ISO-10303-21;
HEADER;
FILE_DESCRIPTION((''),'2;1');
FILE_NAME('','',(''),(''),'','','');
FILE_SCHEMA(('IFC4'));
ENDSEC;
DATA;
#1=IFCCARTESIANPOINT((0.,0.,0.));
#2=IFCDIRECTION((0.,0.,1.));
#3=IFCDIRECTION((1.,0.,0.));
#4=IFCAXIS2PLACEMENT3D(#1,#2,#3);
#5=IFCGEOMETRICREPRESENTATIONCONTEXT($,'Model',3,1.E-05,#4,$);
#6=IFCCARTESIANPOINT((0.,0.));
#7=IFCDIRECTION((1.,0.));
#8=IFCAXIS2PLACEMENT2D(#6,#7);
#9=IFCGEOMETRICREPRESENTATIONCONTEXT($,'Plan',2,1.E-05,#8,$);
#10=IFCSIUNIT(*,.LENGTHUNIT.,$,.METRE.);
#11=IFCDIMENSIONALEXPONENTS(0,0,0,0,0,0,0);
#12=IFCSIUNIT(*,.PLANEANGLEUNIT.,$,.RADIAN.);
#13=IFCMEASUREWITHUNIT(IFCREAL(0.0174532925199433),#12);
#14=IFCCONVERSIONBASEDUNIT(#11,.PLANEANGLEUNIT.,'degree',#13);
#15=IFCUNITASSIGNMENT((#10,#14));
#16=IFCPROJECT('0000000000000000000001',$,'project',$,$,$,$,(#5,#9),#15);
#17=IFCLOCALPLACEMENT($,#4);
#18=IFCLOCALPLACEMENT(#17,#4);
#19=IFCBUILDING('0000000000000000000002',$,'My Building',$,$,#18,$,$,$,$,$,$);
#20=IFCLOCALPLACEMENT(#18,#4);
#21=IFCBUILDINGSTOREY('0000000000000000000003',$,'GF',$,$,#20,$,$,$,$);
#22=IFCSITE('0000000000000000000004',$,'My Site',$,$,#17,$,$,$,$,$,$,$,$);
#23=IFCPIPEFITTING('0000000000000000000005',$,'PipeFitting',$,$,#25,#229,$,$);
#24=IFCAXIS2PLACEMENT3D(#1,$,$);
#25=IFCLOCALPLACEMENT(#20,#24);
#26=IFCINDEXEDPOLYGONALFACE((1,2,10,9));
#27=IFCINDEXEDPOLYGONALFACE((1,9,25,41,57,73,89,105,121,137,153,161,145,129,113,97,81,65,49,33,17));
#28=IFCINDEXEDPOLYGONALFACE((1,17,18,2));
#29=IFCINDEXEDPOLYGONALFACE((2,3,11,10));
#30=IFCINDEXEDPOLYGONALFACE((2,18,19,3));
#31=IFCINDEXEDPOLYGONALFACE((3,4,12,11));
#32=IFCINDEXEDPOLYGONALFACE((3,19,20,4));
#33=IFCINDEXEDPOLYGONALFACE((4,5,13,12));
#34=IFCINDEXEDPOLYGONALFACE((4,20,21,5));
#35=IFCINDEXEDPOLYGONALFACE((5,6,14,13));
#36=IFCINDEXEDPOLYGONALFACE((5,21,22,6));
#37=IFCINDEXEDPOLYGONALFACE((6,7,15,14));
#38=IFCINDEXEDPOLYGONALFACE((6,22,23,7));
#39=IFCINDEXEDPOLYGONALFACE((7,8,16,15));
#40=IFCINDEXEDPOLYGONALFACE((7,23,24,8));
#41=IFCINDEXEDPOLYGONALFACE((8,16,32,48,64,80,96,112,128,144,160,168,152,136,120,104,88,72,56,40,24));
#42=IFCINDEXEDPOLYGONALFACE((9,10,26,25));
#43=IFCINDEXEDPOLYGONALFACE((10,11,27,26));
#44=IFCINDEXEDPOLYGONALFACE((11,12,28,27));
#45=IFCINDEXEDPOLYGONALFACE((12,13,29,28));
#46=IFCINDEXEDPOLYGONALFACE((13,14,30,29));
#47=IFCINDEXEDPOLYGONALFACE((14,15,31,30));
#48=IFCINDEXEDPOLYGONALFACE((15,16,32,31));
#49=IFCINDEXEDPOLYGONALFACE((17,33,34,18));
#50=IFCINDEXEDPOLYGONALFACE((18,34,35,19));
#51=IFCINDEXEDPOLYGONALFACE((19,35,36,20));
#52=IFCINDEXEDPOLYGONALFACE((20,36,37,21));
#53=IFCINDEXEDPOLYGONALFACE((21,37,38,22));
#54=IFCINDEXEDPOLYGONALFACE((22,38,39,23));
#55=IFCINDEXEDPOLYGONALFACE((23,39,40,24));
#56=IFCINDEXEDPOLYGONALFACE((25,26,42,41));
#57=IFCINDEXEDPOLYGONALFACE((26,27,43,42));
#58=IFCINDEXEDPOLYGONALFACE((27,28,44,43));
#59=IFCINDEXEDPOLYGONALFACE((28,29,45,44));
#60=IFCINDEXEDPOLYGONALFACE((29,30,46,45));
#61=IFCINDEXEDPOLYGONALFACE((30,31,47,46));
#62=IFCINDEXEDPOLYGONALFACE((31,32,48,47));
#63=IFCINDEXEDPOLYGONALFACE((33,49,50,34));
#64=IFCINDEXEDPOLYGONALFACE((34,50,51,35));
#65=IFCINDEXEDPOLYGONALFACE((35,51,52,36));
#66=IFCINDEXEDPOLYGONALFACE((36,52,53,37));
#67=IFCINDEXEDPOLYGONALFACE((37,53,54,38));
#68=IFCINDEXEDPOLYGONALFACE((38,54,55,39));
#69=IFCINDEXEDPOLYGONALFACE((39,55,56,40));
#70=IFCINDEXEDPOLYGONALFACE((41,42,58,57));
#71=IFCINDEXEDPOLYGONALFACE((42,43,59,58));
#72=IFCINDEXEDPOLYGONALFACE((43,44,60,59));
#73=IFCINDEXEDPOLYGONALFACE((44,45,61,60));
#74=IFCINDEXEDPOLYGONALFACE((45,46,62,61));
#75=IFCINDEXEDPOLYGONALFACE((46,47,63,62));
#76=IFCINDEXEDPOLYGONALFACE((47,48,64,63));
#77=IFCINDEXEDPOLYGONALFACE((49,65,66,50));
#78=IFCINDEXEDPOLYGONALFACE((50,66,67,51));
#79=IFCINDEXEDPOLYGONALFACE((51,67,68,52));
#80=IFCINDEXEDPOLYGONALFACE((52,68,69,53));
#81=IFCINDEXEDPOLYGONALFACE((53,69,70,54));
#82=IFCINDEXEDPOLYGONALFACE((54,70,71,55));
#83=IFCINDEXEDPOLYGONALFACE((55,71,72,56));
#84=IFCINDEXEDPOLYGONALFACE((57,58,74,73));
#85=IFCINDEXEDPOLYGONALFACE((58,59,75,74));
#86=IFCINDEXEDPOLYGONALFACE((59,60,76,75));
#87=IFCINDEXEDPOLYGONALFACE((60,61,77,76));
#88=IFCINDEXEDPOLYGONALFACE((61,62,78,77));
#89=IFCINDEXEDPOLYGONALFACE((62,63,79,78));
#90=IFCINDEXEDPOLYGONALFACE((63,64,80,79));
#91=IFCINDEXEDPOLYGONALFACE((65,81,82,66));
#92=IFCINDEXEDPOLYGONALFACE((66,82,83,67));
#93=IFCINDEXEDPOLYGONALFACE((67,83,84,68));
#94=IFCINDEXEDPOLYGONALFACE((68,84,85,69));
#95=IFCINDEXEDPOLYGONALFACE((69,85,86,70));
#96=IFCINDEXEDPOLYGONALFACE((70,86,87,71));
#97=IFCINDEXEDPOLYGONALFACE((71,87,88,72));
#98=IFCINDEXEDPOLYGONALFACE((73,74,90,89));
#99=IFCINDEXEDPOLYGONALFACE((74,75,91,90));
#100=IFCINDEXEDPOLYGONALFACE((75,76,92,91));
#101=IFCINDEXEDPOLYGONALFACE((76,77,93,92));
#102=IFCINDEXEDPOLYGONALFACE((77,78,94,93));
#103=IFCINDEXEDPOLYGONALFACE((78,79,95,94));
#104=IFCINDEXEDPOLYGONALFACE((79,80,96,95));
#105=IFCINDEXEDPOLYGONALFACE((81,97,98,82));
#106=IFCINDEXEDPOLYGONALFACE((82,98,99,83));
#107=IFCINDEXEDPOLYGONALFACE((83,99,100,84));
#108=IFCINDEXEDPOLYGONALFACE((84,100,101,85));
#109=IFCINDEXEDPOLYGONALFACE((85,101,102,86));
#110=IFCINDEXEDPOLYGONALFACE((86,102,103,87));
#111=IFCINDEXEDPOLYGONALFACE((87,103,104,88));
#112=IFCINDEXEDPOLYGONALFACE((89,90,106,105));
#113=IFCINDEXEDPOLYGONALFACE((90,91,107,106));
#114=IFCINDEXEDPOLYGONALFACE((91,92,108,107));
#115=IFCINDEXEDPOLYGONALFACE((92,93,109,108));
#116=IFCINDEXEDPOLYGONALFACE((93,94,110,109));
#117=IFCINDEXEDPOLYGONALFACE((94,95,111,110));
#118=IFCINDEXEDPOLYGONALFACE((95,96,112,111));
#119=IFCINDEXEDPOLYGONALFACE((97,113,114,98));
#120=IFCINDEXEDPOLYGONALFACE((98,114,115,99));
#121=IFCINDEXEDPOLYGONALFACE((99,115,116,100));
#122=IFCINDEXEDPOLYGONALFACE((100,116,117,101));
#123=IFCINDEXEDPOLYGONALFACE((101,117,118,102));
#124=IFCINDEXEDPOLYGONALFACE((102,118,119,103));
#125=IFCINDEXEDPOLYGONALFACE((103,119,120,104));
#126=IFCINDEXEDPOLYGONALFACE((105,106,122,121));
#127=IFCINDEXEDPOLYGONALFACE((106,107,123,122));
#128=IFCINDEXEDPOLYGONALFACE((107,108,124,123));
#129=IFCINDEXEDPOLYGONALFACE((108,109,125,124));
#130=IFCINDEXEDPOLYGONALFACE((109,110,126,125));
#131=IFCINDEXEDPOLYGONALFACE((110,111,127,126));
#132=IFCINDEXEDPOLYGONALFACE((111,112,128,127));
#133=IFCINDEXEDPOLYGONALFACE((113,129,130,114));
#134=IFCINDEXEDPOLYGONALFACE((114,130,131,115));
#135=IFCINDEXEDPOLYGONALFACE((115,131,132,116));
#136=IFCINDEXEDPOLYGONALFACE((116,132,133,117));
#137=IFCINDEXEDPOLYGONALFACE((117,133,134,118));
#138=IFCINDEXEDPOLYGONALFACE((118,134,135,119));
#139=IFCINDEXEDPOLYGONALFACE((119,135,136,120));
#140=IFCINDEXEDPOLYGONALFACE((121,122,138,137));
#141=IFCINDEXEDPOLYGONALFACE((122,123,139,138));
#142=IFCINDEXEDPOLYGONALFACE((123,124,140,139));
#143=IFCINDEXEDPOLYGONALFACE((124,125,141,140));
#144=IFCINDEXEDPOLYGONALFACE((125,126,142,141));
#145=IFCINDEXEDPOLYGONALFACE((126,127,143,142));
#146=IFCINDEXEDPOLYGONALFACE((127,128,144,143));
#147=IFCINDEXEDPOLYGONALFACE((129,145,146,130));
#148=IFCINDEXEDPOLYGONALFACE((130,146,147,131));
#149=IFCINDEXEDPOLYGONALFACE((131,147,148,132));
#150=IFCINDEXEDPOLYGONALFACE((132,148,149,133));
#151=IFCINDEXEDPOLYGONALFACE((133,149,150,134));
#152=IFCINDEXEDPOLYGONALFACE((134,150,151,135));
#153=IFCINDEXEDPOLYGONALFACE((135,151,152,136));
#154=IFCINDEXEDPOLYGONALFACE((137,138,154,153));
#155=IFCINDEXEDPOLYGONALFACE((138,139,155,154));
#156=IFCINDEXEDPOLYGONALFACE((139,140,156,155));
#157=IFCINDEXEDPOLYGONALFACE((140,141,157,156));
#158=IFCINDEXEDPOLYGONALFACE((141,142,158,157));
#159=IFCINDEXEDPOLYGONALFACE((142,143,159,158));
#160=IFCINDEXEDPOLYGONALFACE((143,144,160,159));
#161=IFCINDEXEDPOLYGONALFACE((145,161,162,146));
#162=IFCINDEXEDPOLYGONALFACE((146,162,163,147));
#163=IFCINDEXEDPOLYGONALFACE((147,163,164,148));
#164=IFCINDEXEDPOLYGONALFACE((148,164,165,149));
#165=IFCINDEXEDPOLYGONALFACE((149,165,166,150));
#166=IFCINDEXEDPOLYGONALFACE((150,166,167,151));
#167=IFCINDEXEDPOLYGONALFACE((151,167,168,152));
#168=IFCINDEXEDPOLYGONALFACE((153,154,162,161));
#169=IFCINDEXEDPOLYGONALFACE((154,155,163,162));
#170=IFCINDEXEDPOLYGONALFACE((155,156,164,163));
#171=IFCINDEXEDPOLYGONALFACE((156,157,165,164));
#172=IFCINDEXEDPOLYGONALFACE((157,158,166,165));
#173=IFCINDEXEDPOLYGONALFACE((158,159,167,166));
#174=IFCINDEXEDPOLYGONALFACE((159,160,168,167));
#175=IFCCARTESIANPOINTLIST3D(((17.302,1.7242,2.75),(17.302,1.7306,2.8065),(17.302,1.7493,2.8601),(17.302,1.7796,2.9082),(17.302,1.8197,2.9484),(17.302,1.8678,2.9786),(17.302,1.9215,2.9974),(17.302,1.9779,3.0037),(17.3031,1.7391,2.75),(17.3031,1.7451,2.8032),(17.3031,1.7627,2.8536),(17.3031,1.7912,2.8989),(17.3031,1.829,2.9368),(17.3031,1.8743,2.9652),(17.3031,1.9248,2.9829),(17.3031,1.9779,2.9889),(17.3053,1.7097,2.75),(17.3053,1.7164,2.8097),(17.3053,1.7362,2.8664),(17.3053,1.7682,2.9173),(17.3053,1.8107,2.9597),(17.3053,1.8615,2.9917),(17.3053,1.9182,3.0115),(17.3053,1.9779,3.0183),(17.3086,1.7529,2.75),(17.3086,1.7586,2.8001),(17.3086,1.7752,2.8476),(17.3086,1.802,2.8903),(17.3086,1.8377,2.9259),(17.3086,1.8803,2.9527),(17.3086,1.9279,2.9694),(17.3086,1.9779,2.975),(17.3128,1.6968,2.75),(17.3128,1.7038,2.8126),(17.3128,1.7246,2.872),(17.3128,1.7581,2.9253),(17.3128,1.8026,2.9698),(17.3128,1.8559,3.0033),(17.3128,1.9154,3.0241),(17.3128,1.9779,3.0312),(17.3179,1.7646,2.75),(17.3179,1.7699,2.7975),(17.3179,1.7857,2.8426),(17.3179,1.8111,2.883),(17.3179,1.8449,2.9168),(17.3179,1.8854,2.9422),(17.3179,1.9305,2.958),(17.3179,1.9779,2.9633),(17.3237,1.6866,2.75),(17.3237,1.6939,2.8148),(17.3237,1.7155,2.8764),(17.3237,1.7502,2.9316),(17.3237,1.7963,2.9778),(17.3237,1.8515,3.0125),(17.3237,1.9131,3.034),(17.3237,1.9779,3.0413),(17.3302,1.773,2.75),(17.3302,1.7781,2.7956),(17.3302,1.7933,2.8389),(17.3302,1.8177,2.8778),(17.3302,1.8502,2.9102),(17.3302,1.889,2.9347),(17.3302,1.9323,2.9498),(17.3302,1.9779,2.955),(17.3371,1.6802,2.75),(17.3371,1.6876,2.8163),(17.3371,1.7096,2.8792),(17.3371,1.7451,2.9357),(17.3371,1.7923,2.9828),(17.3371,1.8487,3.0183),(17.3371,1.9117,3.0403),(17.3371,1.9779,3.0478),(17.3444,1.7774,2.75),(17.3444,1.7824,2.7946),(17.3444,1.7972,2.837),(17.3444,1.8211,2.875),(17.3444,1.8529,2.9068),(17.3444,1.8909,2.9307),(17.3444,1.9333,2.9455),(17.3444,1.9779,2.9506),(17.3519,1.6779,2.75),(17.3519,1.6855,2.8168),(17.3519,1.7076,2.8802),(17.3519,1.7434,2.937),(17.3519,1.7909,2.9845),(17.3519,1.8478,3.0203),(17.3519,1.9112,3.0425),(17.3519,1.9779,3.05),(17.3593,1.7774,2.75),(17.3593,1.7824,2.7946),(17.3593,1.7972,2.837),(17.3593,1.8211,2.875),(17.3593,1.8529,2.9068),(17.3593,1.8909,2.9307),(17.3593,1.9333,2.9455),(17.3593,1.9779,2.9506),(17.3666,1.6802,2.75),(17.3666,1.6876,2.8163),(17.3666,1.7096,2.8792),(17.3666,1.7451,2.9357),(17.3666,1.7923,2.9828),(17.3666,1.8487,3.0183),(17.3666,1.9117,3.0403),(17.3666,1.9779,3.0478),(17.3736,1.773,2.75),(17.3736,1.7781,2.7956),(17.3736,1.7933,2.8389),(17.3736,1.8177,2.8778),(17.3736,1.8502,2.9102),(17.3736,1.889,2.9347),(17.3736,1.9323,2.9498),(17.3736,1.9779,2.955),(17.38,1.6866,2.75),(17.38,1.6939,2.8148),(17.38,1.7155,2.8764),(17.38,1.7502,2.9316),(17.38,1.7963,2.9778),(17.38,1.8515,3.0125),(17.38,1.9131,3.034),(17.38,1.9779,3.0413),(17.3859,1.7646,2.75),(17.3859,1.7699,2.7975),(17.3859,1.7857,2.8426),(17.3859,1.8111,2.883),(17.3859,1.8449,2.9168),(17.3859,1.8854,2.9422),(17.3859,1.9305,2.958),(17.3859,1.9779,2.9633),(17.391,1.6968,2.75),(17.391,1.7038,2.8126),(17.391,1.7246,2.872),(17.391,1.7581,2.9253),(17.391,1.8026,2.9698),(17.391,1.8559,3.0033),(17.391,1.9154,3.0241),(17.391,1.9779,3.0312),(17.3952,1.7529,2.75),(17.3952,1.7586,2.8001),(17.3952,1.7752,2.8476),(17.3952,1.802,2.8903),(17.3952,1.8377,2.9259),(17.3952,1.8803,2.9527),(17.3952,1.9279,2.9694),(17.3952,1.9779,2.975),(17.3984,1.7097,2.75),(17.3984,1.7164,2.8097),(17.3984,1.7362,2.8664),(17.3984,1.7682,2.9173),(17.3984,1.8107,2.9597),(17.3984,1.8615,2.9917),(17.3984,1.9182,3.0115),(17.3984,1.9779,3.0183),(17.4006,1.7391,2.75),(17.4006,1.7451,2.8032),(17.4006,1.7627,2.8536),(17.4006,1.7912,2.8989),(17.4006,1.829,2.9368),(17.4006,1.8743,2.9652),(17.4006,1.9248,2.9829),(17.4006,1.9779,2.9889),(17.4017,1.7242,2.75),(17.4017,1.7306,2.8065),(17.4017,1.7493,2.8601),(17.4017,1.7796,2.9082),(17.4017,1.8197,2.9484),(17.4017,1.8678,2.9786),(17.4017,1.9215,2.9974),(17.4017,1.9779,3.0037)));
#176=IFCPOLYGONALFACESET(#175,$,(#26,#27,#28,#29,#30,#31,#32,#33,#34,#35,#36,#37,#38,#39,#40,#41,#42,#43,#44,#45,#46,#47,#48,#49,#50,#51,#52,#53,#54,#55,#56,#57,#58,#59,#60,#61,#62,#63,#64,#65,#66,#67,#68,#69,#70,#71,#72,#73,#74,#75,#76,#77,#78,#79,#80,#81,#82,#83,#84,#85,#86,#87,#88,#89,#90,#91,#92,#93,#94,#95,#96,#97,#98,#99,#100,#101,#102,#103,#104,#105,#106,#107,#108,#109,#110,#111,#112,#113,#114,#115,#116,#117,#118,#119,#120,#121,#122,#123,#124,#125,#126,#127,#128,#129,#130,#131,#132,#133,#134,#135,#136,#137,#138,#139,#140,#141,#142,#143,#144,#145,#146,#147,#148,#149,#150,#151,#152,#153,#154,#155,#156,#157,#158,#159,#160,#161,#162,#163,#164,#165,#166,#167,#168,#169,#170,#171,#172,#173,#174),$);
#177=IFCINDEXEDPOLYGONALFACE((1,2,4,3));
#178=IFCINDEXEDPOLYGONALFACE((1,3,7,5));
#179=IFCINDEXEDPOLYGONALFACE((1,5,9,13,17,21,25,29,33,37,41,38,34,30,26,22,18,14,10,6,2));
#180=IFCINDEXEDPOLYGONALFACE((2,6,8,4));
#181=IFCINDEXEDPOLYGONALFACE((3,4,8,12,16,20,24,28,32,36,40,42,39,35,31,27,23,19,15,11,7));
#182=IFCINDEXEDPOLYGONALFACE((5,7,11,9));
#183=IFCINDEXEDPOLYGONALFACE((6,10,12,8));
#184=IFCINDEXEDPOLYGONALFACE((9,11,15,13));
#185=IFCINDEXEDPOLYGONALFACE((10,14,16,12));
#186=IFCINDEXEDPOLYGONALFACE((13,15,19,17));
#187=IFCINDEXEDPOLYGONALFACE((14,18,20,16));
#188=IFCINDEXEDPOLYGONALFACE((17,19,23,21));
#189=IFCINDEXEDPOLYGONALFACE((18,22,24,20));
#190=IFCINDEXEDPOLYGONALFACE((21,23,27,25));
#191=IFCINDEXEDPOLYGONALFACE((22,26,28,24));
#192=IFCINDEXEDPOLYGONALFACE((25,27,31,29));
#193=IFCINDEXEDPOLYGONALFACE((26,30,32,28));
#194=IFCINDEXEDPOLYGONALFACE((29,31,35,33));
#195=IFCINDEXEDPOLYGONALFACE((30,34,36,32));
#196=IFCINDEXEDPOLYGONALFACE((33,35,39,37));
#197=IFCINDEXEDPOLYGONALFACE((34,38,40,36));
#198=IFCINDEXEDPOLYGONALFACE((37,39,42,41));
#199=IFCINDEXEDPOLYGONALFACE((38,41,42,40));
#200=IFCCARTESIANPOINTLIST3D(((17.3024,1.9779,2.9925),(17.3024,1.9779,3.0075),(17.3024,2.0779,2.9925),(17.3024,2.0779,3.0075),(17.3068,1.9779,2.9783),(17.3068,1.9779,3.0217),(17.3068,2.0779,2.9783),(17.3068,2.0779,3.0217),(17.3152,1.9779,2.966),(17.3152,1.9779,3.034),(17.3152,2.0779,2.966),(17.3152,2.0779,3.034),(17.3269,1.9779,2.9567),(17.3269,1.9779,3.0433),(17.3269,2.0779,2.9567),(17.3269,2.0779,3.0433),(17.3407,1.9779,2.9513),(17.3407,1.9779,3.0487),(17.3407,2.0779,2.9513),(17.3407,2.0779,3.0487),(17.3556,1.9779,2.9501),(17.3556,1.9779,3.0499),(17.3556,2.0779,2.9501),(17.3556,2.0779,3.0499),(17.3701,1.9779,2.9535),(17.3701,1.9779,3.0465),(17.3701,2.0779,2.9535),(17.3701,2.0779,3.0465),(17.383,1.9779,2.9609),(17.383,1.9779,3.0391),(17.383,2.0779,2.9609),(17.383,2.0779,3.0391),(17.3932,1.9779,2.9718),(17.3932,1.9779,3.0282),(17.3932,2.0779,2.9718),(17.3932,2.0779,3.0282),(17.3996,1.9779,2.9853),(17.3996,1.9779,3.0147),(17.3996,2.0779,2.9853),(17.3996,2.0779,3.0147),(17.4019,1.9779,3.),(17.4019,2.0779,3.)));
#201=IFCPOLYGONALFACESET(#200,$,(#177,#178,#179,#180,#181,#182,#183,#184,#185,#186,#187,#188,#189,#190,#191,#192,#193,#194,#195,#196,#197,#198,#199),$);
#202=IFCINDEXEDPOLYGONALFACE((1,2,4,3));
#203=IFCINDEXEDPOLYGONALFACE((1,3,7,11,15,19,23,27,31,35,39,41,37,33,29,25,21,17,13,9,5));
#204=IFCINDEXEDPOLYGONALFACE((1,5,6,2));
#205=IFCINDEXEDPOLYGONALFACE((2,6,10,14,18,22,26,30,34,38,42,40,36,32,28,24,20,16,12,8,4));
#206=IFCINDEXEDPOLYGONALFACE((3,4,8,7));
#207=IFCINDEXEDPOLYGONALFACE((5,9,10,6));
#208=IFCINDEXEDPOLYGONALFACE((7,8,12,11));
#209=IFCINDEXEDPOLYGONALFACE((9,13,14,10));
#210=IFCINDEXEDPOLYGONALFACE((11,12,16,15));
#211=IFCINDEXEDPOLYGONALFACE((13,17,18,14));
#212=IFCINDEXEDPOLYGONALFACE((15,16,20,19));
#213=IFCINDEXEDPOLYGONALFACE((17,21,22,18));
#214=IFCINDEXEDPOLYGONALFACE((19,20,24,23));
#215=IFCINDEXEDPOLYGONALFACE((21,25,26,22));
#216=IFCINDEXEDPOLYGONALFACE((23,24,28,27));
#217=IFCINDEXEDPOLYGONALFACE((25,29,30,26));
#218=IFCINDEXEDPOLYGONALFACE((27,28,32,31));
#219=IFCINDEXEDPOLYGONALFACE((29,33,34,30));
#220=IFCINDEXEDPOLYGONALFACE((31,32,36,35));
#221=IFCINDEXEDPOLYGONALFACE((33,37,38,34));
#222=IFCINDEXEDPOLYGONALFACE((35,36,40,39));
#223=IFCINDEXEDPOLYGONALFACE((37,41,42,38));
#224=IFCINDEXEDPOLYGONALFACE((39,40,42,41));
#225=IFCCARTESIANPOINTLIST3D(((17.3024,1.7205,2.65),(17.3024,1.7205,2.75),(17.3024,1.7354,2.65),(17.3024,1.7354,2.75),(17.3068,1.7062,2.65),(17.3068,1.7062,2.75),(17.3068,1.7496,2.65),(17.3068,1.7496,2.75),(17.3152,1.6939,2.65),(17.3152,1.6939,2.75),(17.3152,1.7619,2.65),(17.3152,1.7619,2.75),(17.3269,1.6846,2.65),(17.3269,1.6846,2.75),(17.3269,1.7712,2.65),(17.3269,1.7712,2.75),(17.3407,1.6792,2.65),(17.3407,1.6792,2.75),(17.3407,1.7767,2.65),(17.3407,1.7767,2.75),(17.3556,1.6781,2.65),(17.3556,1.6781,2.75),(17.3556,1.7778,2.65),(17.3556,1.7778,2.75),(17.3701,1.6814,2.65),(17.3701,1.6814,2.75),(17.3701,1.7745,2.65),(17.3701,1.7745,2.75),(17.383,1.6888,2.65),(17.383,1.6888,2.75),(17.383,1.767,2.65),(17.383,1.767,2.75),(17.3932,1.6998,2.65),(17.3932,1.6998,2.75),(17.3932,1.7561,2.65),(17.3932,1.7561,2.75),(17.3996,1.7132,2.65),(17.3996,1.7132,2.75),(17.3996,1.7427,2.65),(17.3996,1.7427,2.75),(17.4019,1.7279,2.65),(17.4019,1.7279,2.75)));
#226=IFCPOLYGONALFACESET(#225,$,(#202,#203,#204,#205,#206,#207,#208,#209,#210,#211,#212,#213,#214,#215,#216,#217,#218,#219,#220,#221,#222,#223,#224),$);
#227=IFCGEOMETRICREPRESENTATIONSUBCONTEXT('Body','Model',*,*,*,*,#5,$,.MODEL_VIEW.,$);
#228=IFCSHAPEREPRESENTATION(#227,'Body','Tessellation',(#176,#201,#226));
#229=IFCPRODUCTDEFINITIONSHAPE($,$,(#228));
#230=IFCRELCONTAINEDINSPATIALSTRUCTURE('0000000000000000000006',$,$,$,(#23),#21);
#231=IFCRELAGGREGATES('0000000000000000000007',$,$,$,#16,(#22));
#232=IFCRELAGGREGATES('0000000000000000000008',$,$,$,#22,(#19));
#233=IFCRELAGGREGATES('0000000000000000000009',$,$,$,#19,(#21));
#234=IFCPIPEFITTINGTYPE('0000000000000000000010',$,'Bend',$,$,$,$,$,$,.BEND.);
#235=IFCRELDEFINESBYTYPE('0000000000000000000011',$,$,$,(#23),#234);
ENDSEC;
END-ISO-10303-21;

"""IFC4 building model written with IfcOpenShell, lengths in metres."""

from ifc_helpers import new_model, entity, si_unit, converted_unit, frame, origin_with_axes, origin_2d_with_axis, place, context, subcontext, project, spatial, circle, extrude, source, transform, mapped, type_object, type_shapes, element, save


model = new_model("IFC4")

# Units and contexts
model_context = context("Model", 3, precision=1e-05, world=origin_with_axes())
plan_context = context("Plan", 2, precision=1e-05, world=origin_2d_with_axis())
body_context = subcontext(model_context, "Body", "Model", "MODEL_VIEW")
ifc_project = project(units=[si_unit("LENGTHUNIT", "METRE"), converted_unit("PLANEANGLEUNIT", "degree", entity("IfcReal", 0.0174532925199433), si_unit("PLANEANGLEUNIT", "RADIAN"), dimensions=[0, 0, 0, 0, 0, 0, 0])], contexts=[model_context, plan_context])

# Site, building, storey
site_placement = place(None, origin_with_axes())
site = spatial("IfcSite", under=ifc_project, at=site_placement, Name="My Site")
building_placement = place(site_placement, origin_with_axes())
building = spatial("IfcBuilding", under=site, at=building_placement, Name="My Building")
storey_placement = place(building_placement, origin_with_axes())
storey = spatial("IfcBuildingStorey", under=building, at=storey_placement, Name="GF")

# Pipe fitting
pipe_fitting_type = type_object("IfcPipeFittingType", Name="Bend", PredefinedType="BEND")
shared_shape = source(origin_with_axes(), body_context, "Body", "SolidModel", [
    entity("IfcSweptDiskSolid", entity("IfcIndexedPolyCurve", entity("IfcCartesianPointList3D", [[0.0, 0.0, 0.1], [0.0, -0.0732, 0.2768], [0.0, -0.25, 0.35]]), [entity("IfcArcIndex", [1, 2, 3])]), 0.05),
    extrude(circle(Radius=0.05), origin_with_axes(), (0.0, 0.0, 1.0), 0.1),
    extrude(circle(Radius=0.05), frame((0.0, -0.25, 0.35), z_axis=(0.0, -1.0, 0.0), x_axis=(1.0, 0.0, 0.0)), (0.0, 0.0, 1.0), 0.1),
])
type_shapes(pipe_fitting_type, [shared_shape])
for number, where, z_axis, x_axis, name in (
    (1, (17.3519, 2.0779, 3.0), (0.0, -1.0, 0.0), (1.0, 0.0, 0.0), "PipeFitting"),
):
    element("IfcPipeFitting", number, at=place(storey_placement, frame(where, z_axis=z_axis, x_axis=x_axis)), inside=storey, type_object=pipe_fitting_type, Name=name, context=body_context, shape_type="MappedRepresentation", body=[
        mapped(shared_shape, transform((0.0, 0.0, 0.0), x_axis=(1.0, 0.0, 0.0), y_axis=(0.0, 1.0, 0.0), z_axis=(0.0, 0.0, 1.0), scale=1.0)),
    ])

save(model, "model.ifc")
